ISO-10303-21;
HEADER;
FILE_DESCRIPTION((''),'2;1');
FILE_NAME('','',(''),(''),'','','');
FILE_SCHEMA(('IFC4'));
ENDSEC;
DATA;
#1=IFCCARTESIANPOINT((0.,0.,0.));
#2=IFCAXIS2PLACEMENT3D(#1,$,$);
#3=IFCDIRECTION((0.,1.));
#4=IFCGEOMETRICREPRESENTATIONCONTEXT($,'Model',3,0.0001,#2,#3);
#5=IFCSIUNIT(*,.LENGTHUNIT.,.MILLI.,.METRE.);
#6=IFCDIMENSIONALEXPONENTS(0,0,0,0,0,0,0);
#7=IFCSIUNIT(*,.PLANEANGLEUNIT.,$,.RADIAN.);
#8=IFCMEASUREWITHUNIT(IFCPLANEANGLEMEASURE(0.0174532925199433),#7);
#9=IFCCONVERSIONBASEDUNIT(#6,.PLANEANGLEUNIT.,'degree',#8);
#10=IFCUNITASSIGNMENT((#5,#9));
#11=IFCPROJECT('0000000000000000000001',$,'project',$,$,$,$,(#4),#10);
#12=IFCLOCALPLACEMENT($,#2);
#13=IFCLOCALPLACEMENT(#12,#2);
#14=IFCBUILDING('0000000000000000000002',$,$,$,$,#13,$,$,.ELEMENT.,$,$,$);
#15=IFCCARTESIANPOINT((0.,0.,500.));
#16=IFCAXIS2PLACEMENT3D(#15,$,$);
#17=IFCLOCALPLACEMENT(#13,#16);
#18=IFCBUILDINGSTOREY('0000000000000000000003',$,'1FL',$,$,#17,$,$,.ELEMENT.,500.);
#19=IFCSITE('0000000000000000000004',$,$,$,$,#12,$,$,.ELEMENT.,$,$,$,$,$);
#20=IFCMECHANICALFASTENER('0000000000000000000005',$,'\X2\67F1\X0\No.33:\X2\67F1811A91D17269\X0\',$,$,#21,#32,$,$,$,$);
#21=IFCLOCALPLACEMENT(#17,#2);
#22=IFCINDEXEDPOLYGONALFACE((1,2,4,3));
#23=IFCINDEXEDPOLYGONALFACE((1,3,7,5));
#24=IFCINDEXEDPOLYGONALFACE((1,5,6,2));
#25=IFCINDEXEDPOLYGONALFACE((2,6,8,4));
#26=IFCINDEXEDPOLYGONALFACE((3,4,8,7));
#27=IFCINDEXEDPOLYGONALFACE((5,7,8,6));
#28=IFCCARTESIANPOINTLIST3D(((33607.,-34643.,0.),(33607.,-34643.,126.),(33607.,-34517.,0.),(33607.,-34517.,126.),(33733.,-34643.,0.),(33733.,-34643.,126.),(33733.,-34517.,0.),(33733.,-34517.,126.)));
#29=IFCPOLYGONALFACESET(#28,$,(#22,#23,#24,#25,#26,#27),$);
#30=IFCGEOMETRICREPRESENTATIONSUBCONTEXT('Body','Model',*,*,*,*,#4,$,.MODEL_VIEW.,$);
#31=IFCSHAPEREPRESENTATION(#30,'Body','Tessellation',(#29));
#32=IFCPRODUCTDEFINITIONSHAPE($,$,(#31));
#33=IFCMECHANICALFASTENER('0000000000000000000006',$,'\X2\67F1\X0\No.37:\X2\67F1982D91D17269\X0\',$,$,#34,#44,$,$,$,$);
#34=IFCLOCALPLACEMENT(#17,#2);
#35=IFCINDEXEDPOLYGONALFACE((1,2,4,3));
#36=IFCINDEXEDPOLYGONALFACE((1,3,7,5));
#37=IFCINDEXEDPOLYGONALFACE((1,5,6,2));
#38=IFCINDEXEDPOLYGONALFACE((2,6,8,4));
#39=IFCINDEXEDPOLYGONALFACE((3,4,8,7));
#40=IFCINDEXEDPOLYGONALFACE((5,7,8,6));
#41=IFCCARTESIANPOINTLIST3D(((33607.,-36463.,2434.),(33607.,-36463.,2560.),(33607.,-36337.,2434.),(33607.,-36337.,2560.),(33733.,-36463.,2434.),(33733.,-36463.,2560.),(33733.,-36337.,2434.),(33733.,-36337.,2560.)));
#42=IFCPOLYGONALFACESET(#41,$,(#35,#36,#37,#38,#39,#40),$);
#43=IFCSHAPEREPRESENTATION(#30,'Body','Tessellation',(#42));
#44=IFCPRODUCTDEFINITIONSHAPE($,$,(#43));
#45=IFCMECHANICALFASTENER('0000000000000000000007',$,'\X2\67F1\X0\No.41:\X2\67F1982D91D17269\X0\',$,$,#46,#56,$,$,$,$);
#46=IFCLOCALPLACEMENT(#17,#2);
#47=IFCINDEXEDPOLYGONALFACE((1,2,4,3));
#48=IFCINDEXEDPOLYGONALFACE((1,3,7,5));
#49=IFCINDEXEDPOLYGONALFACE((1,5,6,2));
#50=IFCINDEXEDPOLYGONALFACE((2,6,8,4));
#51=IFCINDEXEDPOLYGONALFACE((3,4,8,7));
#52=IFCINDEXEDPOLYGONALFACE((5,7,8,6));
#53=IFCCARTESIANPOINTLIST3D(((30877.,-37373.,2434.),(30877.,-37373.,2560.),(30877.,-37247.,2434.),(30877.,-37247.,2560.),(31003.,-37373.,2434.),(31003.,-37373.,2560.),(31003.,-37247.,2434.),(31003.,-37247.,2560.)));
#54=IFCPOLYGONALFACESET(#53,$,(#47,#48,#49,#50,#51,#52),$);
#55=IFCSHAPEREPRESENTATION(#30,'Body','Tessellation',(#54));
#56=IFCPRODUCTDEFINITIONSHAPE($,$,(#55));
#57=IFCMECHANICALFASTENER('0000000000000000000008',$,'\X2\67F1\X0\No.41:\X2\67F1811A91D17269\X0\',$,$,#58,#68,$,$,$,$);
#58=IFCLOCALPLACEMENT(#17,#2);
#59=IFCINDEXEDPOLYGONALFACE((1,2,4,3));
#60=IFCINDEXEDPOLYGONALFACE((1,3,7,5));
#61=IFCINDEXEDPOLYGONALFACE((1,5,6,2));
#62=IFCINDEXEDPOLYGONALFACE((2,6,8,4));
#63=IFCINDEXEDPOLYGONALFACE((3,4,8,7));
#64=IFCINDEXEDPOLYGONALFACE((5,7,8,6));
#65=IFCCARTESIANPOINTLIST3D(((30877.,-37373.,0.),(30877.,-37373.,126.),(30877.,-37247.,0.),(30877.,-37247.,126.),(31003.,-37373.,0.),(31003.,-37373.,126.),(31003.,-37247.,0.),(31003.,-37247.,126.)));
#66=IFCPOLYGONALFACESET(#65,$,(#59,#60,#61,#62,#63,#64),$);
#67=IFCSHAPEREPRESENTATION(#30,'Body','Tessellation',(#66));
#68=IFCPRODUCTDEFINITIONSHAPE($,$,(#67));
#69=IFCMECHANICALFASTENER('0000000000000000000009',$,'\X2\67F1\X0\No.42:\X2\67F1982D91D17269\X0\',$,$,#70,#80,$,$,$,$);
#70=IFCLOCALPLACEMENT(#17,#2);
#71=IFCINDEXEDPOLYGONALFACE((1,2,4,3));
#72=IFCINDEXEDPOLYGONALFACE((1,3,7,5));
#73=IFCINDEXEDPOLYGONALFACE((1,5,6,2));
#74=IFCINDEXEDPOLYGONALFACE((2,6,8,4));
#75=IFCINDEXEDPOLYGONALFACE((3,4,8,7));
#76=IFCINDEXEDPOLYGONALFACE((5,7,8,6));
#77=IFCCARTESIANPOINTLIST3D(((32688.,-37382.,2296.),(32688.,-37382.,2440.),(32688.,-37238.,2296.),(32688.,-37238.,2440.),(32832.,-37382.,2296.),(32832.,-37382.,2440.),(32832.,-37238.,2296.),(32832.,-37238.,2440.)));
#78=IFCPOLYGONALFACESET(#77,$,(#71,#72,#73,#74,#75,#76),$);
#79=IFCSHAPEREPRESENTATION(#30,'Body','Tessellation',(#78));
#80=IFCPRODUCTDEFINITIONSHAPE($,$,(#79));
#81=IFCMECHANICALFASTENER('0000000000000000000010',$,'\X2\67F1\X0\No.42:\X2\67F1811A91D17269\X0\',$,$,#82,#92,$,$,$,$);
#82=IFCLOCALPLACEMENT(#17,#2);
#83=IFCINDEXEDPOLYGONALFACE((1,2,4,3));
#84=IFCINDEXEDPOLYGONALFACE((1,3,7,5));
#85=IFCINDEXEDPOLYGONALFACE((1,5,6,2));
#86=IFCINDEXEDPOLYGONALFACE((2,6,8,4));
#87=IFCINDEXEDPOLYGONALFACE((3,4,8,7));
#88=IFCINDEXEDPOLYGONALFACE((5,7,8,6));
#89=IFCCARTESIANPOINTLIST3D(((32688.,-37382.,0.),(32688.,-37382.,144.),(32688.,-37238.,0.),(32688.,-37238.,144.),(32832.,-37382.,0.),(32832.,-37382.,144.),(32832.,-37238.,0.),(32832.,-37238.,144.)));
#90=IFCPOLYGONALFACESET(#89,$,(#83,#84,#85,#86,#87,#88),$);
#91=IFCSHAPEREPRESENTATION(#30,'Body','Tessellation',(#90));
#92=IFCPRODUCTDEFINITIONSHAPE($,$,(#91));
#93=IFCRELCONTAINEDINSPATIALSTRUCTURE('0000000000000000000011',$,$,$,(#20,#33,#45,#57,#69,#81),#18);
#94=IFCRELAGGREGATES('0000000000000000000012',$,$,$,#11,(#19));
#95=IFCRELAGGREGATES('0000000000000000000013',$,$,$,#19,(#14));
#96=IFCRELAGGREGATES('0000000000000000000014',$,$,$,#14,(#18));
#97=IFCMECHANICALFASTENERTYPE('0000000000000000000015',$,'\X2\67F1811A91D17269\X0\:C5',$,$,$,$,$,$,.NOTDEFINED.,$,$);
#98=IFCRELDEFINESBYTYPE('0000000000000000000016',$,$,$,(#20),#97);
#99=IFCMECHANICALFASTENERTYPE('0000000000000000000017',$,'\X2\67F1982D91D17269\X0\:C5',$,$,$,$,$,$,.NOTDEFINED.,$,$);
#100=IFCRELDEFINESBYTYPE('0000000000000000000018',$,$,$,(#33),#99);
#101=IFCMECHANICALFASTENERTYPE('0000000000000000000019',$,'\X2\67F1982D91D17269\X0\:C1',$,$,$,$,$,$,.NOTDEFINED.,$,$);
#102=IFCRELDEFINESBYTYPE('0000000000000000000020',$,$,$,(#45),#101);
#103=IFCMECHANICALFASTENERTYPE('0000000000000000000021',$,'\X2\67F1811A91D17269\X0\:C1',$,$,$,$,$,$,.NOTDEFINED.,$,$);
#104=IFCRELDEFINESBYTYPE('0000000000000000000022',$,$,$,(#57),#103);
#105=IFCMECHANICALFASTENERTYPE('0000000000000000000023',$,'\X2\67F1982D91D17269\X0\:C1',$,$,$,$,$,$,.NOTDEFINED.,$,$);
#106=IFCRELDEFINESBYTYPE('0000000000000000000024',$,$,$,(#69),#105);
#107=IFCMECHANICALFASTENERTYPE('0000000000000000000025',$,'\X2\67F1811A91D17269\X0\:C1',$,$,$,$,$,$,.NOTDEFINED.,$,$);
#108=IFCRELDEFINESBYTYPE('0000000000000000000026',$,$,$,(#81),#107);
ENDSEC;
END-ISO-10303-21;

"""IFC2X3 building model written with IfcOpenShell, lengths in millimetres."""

from ifc_helpers import new_model, entity, si_unit, converted_unit, direction, frame, origin, origin_with_axes, origin_2d, place, context, subcontext, project, spatial, rectangle, extrude, type_object, element, save


model = new_model("IFC2X3")

# Units and contexts
model_context = context("Model", 3, precision=0.0001, world=origin(), true_north=direction((0.0, 1.0)))
body_context = subcontext(model_context, "Body", "Model", "MODEL_VIEW")
ifc_project = project(units=[si_unit("LENGTHUNIT", "METRE", prefix="MILLI"), converted_unit("PLANEANGLEUNIT", "degree", entity("IfcPlaneAngleMeasure", 0.0174532925199433), si_unit("PLANEANGLEUNIT", "RADIAN"), dimensions=[0, 0, 0, 0, 0, 0, 0])], contexts=[model_context])

# Site, building, storey
site_placement = place(None, origin())
site = spatial("IfcSite", under=ifc_project, at=site_placement, CompositionType="ELEMENT")
building_placement = place(site_placement, origin())
building = spatial("IfcBuilding", under=site, at=building_placement, CompositionType="ELEMENT")
storey_placement = place(building_placement, frame((0.0, 0.0, 500.0)))
storey = spatial("IfcBuildingStorey", under=building, at=storey_placement, Name="1FL", CompositionType="ELEMENT", Elevation=500.0)

# Mechanical fasteners
mechanical_fastener_type_1 = type_object("IfcMechanicalFastenerType", Name="柱脚金物:C5")
mechanical_fastener_1_placement = place(storey_placement, frame((33670.0, -34580.0, 0.0)))
element("IfcMechanicalFastener", 1, at=mechanical_fastener_1_placement, inside=storey, type_object=mechanical_fastener_type_1, Name="柱No.33:柱脚金物", context=body_context, shape_type="SweptSolid", body=[
    extrude(rectangle(XDim=126.0, YDim=126.0, at=origin_2d()), origin_with_axes(), (0.0, 0.0, 1.0), 126.0),
])
mechanical_fastener_type_2 = type_object("IfcMechanicalFastenerType", Name="柱頭金物:C5")
mechanical_fastener_2_placement = place(storey_placement, frame((33670.0, -36400.0, 2434.0)))
element("IfcMechanicalFastener", 2, at=mechanical_fastener_2_placement, inside=storey, type_object=mechanical_fastener_type_2, Name="柱No.37:柱頭金物", context=body_context, shape_type="SweptSolid", body=[
    extrude(rectangle(XDim=126.0, YDim=126.0, at=origin_2d()), origin_with_axes(), (0.0, 0.0, 1.0), 126.0),
])
mechanical_fastener_type_3 = type_object("IfcMechanicalFastenerType", Name="柱頭金物:C1")
mechanical_fastener_3_placement = place(storey_placement, frame((30940.0, -37310.0, 2434.0)))
element("IfcMechanicalFastener", 3, at=mechanical_fastener_3_placement, inside=storey, type_object=mechanical_fastener_type_3, Name="柱No.41:柱頭金物", context=body_context, shape_type="SweptSolid", body=[
    extrude(rectangle(XDim=126.0, YDim=126.0, at=origin_2d()), origin_with_axes(), (0.0, 0.0, 1.0), 126.0),
])
mechanical_fastener_type_4 = type_object("IfcMechanicalFastenerType", Name="柱脚金物:C1")
mechanical_fastener_4_placement = place(storey_placement, frame((30940.0, -37310.0, 0.0)))
element("IfcMechanicalFastener", 4, at=mechanical_fastener_4_placement, inside=storey, type_object=mechanical_fastener_type_4, Name="柱No.41:柱脚金物", context=body_context, shape_type="SweptSolid", body=[
    extrude(rectangle(XDim=126.0, YDim=126.0, at=origin_2d()), origin_with_axes(), (0.0, 0.0, 1.0), 126.0),
])
mechanical_fastener_type_5 = type_object("IfcMechanicalFastenerType", Name="柱頭金物:C1")
mechanical_fastener_5_placement = place(storey_placement, frame((32760.0, -37310.0, 2296.0)))
element("IfcMechanicalFastener", 5, at=mechanical_fastener_5_placement, inside=storey, type_object=mechanical_fastener_type_5, Name="柱No.42:柱頭金物", context=body_context, shape_type="SweptSolid", body=[
    extrude(rectangle(XDim=144.0, YDim=144.0, at=origin_2d()), origin_with_axes(), (0.0, 0.0, 1.0), 144.0),
])
mechanical_fastener_type_6 = type_object("IfcMechanicalFastenerType", Name="柱脚金物:C1")
mechanical_fastener_6_placement = place(storey_placement, frame((32760.0, -37310.0, 0.0)))
element("IfcMechanicalFastener", 6, at=mechanical_fastener_6_placement, inside=storey, type_object=mechanical_fastener_type_6, Name="柱No.42:柱脚金物", context=body_context, shape_type="SweptSolid", body=[
    extrude(rectangle(XDim=144.0, YDim=144.0, at=origin_2d()), origin_with_axes(), (0.0, 0.0, 1.0), 144.0),
])

save(model, "model.ifc")
